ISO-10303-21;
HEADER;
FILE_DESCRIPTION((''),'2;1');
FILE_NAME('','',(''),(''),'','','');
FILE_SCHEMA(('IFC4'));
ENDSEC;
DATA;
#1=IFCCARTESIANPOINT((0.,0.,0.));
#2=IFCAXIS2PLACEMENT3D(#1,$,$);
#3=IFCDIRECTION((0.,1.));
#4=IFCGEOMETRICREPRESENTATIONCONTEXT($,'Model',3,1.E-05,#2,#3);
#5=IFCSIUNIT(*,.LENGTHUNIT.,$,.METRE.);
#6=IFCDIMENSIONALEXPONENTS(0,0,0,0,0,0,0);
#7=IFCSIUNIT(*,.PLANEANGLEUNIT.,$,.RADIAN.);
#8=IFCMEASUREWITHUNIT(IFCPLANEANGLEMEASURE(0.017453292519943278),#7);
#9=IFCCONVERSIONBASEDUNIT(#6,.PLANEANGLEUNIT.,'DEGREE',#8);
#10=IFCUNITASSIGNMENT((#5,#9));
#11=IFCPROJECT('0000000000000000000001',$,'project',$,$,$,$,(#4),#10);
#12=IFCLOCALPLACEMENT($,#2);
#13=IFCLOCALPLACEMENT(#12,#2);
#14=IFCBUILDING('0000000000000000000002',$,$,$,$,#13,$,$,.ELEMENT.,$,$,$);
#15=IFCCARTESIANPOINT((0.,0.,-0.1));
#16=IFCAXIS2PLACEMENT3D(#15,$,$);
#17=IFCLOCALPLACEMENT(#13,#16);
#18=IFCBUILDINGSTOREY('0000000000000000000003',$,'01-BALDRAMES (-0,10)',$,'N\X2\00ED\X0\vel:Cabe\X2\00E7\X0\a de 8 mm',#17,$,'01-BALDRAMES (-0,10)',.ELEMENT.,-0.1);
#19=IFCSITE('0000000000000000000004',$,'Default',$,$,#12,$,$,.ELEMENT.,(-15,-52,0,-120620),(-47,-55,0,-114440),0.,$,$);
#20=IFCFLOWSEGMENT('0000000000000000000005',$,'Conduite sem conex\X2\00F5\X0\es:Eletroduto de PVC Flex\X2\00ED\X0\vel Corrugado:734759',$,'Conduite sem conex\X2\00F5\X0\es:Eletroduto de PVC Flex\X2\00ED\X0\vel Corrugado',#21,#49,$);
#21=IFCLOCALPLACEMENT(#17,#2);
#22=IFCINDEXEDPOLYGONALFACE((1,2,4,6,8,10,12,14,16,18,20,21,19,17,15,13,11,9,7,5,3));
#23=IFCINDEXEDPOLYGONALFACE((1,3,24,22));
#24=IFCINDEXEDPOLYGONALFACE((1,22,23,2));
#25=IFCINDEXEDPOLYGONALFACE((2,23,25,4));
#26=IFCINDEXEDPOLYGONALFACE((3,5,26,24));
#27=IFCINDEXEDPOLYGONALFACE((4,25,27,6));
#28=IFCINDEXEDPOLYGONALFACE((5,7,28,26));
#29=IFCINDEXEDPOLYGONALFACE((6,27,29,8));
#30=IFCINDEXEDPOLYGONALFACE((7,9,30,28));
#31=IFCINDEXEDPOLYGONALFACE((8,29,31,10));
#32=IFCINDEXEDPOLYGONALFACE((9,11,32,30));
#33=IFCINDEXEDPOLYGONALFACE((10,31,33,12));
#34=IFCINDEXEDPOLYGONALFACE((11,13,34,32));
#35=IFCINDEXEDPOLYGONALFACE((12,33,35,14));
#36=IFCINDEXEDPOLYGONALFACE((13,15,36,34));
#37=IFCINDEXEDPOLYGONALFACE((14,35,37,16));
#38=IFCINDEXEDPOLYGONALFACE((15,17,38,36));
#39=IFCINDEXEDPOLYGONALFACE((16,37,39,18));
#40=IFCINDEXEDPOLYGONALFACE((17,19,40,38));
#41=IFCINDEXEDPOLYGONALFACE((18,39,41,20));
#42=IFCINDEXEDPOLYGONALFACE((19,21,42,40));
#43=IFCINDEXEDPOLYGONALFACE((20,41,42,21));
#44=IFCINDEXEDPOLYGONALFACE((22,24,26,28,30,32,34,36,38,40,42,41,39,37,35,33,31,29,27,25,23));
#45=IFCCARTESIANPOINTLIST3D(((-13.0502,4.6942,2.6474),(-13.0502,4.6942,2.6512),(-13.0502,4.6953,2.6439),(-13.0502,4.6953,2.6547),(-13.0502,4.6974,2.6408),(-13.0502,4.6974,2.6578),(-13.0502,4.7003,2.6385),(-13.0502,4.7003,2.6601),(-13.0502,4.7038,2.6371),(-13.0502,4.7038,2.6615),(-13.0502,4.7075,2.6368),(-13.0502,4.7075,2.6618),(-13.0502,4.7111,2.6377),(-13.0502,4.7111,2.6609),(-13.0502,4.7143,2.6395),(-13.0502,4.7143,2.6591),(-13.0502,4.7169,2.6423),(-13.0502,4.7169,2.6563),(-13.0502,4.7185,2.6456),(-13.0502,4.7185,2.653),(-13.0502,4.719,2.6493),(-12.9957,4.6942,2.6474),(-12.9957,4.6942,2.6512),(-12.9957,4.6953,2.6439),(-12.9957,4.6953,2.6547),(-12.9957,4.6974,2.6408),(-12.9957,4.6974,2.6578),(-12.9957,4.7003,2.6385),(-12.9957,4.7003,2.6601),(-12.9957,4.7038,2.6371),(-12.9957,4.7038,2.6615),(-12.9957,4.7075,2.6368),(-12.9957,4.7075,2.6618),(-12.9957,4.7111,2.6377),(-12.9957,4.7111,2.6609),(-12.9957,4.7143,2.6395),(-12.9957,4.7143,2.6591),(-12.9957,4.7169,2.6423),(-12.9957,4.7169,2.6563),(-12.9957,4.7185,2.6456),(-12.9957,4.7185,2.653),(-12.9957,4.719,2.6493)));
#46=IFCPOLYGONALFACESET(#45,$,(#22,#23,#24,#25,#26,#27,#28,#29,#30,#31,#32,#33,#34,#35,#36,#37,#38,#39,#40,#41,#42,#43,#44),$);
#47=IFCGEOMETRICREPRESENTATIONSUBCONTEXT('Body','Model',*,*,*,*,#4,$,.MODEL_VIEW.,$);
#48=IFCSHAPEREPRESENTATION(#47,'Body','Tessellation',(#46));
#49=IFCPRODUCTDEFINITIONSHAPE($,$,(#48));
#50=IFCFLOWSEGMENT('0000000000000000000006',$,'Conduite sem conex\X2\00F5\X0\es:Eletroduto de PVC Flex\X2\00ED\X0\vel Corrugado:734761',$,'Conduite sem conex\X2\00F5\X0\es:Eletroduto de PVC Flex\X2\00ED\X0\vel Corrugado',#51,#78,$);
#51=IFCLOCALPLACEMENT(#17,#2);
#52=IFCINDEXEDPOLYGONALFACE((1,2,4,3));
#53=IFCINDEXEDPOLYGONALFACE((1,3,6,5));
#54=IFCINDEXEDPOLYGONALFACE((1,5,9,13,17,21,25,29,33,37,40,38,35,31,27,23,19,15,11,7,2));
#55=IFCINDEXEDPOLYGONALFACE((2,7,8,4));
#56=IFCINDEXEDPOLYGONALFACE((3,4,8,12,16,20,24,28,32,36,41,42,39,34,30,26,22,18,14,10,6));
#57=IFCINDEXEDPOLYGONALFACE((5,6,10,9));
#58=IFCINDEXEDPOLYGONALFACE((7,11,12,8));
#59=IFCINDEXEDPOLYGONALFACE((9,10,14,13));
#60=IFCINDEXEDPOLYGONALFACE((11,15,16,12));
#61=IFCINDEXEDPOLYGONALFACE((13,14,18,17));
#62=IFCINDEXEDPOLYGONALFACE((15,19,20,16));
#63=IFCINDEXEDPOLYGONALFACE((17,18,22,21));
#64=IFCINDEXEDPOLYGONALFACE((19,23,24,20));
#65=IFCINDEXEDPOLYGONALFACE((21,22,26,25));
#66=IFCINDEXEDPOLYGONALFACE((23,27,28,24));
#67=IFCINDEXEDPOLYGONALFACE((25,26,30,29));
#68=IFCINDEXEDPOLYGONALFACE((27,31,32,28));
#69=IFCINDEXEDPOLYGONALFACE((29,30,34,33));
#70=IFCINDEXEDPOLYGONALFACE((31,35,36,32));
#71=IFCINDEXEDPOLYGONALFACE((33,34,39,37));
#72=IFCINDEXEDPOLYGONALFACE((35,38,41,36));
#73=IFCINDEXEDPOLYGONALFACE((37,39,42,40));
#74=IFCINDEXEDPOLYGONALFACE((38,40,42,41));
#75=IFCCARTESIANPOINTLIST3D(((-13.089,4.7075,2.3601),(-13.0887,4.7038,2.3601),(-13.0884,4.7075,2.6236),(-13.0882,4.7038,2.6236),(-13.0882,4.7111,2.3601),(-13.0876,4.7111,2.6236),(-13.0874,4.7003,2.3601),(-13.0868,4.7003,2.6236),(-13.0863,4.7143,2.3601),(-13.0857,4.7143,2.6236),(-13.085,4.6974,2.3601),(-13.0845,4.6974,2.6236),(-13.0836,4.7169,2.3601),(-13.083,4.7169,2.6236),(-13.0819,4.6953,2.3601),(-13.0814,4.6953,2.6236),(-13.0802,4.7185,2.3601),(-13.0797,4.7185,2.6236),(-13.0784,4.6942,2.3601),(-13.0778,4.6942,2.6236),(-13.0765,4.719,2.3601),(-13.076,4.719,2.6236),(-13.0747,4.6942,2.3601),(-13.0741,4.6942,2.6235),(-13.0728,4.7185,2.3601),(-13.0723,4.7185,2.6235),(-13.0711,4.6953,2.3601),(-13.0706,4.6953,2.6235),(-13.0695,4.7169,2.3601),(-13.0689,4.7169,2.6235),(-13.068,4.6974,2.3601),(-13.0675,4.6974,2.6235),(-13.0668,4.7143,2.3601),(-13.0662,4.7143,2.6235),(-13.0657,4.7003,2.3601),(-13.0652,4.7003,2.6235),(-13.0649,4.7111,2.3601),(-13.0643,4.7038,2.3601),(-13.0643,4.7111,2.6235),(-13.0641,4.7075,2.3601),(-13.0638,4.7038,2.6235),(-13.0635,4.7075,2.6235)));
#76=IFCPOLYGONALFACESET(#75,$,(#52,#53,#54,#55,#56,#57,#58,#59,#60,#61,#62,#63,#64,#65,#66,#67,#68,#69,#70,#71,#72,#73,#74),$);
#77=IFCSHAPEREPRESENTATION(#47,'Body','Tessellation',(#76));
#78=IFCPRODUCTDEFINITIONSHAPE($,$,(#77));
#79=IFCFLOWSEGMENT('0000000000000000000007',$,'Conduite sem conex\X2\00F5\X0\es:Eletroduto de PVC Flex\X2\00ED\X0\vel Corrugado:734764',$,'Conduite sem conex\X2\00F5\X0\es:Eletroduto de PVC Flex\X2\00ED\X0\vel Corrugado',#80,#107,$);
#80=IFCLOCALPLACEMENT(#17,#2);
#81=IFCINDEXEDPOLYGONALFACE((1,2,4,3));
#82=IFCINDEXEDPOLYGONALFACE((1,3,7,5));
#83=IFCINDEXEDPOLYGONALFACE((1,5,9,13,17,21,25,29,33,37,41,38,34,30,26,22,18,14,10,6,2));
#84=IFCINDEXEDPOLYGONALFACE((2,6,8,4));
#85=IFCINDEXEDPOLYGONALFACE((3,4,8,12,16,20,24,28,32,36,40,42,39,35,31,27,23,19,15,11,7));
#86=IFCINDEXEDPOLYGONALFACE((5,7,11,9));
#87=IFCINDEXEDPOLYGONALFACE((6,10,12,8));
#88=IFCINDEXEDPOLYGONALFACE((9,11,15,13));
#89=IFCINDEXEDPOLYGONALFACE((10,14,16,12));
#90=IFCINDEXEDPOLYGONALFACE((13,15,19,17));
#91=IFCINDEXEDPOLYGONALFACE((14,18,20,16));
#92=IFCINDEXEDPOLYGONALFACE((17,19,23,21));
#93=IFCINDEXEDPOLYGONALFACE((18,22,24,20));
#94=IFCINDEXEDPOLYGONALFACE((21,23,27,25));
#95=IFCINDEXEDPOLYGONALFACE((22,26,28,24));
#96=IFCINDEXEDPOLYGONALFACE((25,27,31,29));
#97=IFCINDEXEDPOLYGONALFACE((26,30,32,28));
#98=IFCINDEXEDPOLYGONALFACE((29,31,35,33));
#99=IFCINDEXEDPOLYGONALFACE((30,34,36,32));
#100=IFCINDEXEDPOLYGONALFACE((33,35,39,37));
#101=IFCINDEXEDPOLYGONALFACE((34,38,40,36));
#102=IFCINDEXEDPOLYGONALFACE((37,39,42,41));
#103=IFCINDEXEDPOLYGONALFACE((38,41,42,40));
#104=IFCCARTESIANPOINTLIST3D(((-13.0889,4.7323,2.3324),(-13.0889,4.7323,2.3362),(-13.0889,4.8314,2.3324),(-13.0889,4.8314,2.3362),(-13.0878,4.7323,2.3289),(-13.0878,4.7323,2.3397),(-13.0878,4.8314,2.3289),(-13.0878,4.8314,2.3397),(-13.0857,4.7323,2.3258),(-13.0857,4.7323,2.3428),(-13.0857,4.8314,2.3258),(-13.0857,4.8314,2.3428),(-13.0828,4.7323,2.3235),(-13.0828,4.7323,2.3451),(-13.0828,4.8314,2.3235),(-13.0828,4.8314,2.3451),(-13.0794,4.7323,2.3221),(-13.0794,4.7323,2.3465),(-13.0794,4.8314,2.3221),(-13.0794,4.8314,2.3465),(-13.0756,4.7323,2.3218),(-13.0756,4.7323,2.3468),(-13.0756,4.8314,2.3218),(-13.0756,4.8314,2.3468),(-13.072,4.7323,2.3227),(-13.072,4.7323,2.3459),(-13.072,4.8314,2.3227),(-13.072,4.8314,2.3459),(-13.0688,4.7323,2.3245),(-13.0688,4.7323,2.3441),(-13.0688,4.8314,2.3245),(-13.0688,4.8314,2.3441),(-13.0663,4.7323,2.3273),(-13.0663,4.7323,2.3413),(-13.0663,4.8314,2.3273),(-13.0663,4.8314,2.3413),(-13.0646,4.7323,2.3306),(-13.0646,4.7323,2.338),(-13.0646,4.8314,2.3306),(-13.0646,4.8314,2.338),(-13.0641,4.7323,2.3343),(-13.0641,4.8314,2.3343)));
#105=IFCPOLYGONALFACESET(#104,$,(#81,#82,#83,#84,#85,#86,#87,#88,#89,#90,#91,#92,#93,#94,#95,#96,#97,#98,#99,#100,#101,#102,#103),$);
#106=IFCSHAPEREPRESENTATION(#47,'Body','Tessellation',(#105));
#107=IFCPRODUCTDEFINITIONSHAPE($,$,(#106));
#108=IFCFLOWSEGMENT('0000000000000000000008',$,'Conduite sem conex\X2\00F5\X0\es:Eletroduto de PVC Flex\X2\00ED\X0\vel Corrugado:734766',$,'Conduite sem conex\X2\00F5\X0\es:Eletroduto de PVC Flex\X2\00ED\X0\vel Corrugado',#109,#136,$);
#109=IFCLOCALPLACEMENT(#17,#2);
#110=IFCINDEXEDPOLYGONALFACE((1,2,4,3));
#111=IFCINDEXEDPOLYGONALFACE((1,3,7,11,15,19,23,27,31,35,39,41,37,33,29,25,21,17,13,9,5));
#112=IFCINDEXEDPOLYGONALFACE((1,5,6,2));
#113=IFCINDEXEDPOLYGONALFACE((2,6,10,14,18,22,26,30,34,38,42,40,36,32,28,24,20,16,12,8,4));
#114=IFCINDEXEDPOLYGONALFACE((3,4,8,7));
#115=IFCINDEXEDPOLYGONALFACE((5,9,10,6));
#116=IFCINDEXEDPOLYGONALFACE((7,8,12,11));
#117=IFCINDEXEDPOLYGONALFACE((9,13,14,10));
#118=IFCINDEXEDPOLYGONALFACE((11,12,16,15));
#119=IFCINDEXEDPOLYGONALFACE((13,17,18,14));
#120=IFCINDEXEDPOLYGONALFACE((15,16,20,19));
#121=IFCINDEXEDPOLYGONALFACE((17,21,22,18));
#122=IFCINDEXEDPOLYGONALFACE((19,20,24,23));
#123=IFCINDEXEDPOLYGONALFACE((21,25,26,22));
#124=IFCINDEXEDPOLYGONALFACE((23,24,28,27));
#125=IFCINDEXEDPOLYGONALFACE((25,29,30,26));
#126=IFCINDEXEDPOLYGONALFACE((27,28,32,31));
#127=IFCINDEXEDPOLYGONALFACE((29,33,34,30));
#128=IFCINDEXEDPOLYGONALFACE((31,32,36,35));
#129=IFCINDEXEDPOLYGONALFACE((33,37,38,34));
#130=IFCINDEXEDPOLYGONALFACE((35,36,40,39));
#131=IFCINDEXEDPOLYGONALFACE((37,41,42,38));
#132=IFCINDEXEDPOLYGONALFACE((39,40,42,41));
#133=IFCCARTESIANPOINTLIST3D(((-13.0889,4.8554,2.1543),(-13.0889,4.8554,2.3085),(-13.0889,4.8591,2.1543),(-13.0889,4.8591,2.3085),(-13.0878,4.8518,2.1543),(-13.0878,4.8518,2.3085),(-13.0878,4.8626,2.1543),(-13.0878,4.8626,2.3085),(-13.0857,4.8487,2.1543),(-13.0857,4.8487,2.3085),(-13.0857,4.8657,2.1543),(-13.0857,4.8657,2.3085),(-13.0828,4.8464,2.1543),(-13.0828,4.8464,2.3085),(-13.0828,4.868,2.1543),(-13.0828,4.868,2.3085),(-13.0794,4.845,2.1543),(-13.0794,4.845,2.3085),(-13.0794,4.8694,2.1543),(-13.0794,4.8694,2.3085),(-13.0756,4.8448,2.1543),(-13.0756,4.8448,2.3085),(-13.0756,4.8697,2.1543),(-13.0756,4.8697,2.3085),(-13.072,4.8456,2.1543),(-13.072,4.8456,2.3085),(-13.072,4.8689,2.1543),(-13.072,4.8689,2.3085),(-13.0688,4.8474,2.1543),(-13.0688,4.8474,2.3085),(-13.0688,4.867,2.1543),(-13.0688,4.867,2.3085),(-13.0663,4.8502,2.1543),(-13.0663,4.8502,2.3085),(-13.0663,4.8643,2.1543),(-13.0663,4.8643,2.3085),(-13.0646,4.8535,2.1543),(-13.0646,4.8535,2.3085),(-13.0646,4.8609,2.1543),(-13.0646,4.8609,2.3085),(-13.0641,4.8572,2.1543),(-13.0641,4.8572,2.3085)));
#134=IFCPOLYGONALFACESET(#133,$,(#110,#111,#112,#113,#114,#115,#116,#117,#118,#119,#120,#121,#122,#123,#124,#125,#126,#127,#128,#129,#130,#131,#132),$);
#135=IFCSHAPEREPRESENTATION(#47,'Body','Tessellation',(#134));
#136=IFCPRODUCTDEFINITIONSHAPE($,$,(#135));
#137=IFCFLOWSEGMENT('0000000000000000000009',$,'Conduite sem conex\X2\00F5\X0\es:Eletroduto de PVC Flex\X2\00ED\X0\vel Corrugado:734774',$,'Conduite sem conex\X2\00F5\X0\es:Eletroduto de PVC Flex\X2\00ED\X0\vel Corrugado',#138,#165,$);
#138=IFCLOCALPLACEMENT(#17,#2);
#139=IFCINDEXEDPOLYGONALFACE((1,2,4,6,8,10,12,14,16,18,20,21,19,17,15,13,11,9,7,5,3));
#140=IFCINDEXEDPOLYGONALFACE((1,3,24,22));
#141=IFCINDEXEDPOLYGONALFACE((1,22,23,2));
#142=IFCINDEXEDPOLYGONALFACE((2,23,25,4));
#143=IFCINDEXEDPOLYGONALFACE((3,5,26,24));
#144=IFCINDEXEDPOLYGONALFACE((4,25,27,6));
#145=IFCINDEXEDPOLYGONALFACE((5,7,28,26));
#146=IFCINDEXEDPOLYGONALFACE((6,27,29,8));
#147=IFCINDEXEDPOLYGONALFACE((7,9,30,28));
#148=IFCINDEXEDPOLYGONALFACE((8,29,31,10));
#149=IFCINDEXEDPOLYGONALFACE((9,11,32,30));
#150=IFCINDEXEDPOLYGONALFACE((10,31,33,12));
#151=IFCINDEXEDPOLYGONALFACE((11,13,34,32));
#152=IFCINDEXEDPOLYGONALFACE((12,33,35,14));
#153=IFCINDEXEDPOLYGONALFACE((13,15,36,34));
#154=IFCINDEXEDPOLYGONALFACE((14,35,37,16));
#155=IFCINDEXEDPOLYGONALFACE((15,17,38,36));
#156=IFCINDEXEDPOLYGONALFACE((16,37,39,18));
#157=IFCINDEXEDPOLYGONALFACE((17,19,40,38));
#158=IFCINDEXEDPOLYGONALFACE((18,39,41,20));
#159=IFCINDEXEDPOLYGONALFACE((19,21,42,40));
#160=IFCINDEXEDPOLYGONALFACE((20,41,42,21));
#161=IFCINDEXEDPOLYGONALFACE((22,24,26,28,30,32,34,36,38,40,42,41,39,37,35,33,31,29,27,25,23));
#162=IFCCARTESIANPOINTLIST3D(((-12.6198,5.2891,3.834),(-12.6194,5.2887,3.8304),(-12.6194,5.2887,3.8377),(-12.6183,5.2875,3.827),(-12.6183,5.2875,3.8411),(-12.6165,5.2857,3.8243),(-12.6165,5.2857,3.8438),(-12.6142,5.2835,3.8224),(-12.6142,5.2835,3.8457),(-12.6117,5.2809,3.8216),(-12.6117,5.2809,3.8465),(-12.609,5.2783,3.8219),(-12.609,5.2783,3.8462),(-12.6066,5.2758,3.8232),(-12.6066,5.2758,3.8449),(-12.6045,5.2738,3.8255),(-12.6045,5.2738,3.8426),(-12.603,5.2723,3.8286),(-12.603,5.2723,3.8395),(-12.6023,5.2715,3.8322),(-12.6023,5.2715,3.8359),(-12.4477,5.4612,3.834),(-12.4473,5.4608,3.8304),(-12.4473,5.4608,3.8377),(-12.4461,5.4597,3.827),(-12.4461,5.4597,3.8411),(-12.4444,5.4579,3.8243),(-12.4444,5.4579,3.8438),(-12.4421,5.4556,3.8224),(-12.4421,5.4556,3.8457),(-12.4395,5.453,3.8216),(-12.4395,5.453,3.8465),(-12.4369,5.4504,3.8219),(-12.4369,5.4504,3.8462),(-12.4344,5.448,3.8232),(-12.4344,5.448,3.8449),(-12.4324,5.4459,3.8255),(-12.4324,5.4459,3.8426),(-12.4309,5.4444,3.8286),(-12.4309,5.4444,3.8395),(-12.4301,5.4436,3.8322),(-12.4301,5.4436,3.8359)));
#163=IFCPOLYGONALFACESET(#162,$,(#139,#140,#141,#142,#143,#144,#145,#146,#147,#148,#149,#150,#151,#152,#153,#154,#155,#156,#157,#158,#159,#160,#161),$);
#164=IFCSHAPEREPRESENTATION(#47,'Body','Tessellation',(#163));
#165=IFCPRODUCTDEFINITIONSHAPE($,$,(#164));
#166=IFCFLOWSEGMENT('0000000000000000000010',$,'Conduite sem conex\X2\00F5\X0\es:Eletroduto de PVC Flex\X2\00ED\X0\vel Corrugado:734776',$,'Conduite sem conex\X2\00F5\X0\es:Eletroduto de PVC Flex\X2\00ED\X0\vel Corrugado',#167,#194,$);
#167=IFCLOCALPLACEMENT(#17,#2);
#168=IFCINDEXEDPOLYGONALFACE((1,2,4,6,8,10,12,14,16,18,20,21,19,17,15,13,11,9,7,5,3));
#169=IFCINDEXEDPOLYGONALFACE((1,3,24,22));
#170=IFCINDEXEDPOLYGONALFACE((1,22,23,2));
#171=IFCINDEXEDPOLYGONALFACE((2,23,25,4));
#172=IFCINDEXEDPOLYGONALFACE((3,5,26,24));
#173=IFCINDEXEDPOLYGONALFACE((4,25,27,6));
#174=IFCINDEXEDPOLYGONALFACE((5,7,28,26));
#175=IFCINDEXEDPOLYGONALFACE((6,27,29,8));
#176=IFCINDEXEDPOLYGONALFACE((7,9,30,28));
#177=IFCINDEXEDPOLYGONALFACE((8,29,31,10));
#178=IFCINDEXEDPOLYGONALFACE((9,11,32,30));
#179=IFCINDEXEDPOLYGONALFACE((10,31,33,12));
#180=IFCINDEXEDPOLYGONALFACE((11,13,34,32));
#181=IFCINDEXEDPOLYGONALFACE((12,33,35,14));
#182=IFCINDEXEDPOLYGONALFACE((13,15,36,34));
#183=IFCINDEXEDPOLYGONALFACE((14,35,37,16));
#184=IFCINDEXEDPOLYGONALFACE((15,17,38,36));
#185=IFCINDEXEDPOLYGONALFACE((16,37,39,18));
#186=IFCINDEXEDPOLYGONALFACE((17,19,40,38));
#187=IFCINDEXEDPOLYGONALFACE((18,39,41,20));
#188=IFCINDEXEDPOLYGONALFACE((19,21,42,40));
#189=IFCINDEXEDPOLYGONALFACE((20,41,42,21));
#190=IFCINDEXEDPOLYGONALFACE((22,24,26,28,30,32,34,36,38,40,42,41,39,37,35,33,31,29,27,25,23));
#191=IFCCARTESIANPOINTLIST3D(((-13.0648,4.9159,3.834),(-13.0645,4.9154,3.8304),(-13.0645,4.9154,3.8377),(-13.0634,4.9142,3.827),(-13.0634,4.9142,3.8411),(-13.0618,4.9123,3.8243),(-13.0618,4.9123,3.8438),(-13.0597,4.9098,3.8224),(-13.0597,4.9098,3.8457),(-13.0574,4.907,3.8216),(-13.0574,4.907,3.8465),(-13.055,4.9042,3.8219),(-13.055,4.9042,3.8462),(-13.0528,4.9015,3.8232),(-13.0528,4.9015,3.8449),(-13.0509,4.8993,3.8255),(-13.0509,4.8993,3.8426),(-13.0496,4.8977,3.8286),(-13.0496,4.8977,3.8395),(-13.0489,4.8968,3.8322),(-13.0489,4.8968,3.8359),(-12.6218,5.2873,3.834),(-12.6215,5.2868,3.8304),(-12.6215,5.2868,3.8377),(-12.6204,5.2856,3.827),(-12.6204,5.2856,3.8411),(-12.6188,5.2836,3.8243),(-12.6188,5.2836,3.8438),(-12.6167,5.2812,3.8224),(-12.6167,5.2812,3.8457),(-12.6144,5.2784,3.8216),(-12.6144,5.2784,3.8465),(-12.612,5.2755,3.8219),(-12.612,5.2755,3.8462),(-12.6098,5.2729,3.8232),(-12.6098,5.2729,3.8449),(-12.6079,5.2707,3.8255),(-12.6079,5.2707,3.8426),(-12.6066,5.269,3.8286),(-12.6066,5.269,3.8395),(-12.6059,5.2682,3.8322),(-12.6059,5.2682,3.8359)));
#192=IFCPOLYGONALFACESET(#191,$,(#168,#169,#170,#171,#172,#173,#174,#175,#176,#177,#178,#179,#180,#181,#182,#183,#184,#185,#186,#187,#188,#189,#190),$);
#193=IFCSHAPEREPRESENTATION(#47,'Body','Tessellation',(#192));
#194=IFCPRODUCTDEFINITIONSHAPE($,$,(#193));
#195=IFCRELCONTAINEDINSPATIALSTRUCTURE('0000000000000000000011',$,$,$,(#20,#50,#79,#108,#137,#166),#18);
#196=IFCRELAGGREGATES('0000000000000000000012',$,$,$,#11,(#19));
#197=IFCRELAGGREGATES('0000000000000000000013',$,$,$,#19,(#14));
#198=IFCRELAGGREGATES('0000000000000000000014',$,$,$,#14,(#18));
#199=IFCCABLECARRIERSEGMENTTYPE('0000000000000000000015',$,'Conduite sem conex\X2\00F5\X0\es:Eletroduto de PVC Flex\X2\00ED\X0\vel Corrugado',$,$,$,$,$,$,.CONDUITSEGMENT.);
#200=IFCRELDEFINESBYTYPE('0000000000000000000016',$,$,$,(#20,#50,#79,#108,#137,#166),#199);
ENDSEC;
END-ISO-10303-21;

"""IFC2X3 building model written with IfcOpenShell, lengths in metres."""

from ifc_helpers import new_model, entity, si_unit, converted_unit, direction, frame, frame_2d, origin, origin_2d_with_axis, place, context, subcontext, project, spatial, circle, extrude, type_object, element, save


model = new_model("IFC2X3")

# Units and contexts
model_context = context("Model", 3, precision=1e-05, world=origin(), true_north=direction((0.0, 1.0)))
body_context = subcontext(model_context, "Body", "Model", "MODEL_VIEW")
ifc_project = project(units=[si_unit("LENGTHUNIT", "METRE"), converted_unit("PLANEANGLEUNIT", "DEGREE", entity("IfcPlaneAngleMeasure", 0.017453292519943278), si_unit("PLANEANGLEUNIT", "RADIAN"), dimensions=[0, 0, 0, 0, 0, 0, 0])], contexts=[model_context])

# Site, building, storey
site_placement = place(None, origin())
site = spatial("IfcSite", under=ifc_project, at=site_placement, Name="Default", CompositionType="ELEMENT", RefLatitude=(-15, -52, 0, -120620), RefLongitude=(-47, -55, 0, -114440), RefElevation=0.0)
building_placement = place(site_placement, origin())
building = spatial("IfcBuilding", under=site, at=building_placement, CompositionType="ELEMENT")
storey_placement = place(building_placement, frame((0.0, 0.0, -0.1)))
storey = spatial("IfcBuildingStorey", under=building, at=storey_placement, Name="01-BALDRAMES (-0,10)", ObjectType="Nível:Cabeça de 8 mm", LongName="01-BALDRAMES (-0,10)", CompositionType="ELEMENT", Elevation=-0.1)

# Flow segments
cable_carrier_segment_type = type_object("IfcCableCarrierSegmentType", Name="Conduite sem conexões:Eletroduto de PVC Flexível Corrugado", PredefinedType="CONDUITSEGMENT")
flow_segment_1_placement = place(storey_placement, origin())
element("IfcFlowSegment", 1, at=flow_segment_1_placement, inside=storey, type_object=cable_carrier_segment_type, Name="Conduite sem conexões:Eletroduto de PVC Flexível Corrugado:734759", ObjectType="Conduite sem conexões:Eletroduto de PVC Flexível Corrugado", context=body_context, shape_type="SweptSolid", body=[
    extrude(circle(Radius=0.0125, at=frame_2d((0.0, 0.0), x_axis=(1.0, 0.0))), frame((-13.0502, 4.7065, 2.6493), z_axis=(1.0, 0.0, 0.0), x_axis=(0.0, 1.0, 0.0)), (0.0, 0.0, 1.0), 0.0544),
])
flow_segment_2_placement = place(storey_placement, origin())
element("IfcFlowSegment", 2, at=flow_segment_2_placement, inside=storey, type_object=cable_carrier_segment_type, Name="Conduite sem conexões:Eletroduto de PVC Flexível Corrugado:734761", ObjectType="Conduite sem conexões:Eletroduto de PVC Flexível Corrugado", context=body_context, shape_type="SweptSolid", body=[
    extrude(circle(Radius=0.0125, at=origin_2d_with_axis()), frame((-13.0765, 4.7065, 2.3601), z_axis=(0.002086, 0.0, 0.999998), x_axis=(-0.000028, 1.0, 0.0)), (0.0, 0.0, 1.0), 0.2635),
])
flow_segment_3_placement = place(storey_placement, origin())
element("IfcFlowSegment", 3, at=flow_segment_3_placement, inside=storey, type_object=cable_carrier_segment_type, Name="Conduite sem conexões:Eletroduto de PVC Flexível Corrugado:734764", ObjectType="Conduite sem conexões:Eletroduto de PVC Flexível Corrugado", context=body_context, shape_type="SweptSolid", body=[
    extrude(circle(Radius=0.0125, at=frame_2d((0.0, 0.0), x_axis=(1.0, 0.0))), frame((-13.0766, 4.7323, 2.3343), z_axis=(0.0, 1.0, 0.0), x_axis=(1.0, 0.0, 0.0)), (0.0, 0.0, 1.0), 0.0991),
])
flow_segment_4_placement = place(storey_placement, origin())
element("IfcFlowSegment", 4, at=flow_segment_4_placement, inside=storey, type_object=cable_carrier_segment_type, Name="Conduite sem conexões:Eletroduto de PVC Flexível Corrugado:734766", ObjectType="Conduite sem conexões:Eletroduto de PVC Flexível Corrugado", context=body_context, shape_type="SweptSolid", body=[
    extrude(circle(Radius=0.0125, at=frame_2d((0.0, 0.0), x_axis=(1.0, 0.0))), frame((-13.0766, 4.8572, 2.1543)), (0.0, 0.0, 1.0), 0.1542),
])
flow_segment_5_placement = place(storey_placement, origin())
element("IfcFlowSegment", 5, at=flow_segment_5_placement, inside=storey, type_object=cable_carrier_segment_type, Name="Conduite sem conexões:Eletroduto de PVC Flexível Corrugado:734774", ObjectType="Conduite sem conexões:Eletroduto de PVC Flexível Corrugado", context=body_context, shape_type="SweptSolid", body=[
    extrude(circle(Radius=0.0125, at=origin_2d_with_axis()), frame((-12.611, 5.2802, 3.834), z_axis=(0.707107, 0.707107, 0.0), x_axis=(-0.707107, 0.707107, 0.0)), (0.0, 0.0, 1.0), 0.2435),
])
flow_segment_6_placement = place(storey_placement, origin())
element("IfcFlowSegment", 6, at=flow_segment_6_placement, inside=storey, type_object=cable_carrier_segment_type, Name="Conduite sem conexões:Eletroduto de PVC Flexível Corrugado:734776", ObjectType="Conduite sem conexões:Eletroduto de PVC Flexível Corrugado", context=body_context, shape_type="SweptSolid", body=[
    extrude(circle(Radius=0.0125, at=origin_2d_with_axis()), frame((-13.0568, 4.9063, 3.834), z_axis=(0.766346, 0.642428, 0.0), x_axis=(-0.642428, 0.766346, 0.0)), (0.0, 0.0, 1.0), 0.5781),
])

save(model, "model.ifc")
